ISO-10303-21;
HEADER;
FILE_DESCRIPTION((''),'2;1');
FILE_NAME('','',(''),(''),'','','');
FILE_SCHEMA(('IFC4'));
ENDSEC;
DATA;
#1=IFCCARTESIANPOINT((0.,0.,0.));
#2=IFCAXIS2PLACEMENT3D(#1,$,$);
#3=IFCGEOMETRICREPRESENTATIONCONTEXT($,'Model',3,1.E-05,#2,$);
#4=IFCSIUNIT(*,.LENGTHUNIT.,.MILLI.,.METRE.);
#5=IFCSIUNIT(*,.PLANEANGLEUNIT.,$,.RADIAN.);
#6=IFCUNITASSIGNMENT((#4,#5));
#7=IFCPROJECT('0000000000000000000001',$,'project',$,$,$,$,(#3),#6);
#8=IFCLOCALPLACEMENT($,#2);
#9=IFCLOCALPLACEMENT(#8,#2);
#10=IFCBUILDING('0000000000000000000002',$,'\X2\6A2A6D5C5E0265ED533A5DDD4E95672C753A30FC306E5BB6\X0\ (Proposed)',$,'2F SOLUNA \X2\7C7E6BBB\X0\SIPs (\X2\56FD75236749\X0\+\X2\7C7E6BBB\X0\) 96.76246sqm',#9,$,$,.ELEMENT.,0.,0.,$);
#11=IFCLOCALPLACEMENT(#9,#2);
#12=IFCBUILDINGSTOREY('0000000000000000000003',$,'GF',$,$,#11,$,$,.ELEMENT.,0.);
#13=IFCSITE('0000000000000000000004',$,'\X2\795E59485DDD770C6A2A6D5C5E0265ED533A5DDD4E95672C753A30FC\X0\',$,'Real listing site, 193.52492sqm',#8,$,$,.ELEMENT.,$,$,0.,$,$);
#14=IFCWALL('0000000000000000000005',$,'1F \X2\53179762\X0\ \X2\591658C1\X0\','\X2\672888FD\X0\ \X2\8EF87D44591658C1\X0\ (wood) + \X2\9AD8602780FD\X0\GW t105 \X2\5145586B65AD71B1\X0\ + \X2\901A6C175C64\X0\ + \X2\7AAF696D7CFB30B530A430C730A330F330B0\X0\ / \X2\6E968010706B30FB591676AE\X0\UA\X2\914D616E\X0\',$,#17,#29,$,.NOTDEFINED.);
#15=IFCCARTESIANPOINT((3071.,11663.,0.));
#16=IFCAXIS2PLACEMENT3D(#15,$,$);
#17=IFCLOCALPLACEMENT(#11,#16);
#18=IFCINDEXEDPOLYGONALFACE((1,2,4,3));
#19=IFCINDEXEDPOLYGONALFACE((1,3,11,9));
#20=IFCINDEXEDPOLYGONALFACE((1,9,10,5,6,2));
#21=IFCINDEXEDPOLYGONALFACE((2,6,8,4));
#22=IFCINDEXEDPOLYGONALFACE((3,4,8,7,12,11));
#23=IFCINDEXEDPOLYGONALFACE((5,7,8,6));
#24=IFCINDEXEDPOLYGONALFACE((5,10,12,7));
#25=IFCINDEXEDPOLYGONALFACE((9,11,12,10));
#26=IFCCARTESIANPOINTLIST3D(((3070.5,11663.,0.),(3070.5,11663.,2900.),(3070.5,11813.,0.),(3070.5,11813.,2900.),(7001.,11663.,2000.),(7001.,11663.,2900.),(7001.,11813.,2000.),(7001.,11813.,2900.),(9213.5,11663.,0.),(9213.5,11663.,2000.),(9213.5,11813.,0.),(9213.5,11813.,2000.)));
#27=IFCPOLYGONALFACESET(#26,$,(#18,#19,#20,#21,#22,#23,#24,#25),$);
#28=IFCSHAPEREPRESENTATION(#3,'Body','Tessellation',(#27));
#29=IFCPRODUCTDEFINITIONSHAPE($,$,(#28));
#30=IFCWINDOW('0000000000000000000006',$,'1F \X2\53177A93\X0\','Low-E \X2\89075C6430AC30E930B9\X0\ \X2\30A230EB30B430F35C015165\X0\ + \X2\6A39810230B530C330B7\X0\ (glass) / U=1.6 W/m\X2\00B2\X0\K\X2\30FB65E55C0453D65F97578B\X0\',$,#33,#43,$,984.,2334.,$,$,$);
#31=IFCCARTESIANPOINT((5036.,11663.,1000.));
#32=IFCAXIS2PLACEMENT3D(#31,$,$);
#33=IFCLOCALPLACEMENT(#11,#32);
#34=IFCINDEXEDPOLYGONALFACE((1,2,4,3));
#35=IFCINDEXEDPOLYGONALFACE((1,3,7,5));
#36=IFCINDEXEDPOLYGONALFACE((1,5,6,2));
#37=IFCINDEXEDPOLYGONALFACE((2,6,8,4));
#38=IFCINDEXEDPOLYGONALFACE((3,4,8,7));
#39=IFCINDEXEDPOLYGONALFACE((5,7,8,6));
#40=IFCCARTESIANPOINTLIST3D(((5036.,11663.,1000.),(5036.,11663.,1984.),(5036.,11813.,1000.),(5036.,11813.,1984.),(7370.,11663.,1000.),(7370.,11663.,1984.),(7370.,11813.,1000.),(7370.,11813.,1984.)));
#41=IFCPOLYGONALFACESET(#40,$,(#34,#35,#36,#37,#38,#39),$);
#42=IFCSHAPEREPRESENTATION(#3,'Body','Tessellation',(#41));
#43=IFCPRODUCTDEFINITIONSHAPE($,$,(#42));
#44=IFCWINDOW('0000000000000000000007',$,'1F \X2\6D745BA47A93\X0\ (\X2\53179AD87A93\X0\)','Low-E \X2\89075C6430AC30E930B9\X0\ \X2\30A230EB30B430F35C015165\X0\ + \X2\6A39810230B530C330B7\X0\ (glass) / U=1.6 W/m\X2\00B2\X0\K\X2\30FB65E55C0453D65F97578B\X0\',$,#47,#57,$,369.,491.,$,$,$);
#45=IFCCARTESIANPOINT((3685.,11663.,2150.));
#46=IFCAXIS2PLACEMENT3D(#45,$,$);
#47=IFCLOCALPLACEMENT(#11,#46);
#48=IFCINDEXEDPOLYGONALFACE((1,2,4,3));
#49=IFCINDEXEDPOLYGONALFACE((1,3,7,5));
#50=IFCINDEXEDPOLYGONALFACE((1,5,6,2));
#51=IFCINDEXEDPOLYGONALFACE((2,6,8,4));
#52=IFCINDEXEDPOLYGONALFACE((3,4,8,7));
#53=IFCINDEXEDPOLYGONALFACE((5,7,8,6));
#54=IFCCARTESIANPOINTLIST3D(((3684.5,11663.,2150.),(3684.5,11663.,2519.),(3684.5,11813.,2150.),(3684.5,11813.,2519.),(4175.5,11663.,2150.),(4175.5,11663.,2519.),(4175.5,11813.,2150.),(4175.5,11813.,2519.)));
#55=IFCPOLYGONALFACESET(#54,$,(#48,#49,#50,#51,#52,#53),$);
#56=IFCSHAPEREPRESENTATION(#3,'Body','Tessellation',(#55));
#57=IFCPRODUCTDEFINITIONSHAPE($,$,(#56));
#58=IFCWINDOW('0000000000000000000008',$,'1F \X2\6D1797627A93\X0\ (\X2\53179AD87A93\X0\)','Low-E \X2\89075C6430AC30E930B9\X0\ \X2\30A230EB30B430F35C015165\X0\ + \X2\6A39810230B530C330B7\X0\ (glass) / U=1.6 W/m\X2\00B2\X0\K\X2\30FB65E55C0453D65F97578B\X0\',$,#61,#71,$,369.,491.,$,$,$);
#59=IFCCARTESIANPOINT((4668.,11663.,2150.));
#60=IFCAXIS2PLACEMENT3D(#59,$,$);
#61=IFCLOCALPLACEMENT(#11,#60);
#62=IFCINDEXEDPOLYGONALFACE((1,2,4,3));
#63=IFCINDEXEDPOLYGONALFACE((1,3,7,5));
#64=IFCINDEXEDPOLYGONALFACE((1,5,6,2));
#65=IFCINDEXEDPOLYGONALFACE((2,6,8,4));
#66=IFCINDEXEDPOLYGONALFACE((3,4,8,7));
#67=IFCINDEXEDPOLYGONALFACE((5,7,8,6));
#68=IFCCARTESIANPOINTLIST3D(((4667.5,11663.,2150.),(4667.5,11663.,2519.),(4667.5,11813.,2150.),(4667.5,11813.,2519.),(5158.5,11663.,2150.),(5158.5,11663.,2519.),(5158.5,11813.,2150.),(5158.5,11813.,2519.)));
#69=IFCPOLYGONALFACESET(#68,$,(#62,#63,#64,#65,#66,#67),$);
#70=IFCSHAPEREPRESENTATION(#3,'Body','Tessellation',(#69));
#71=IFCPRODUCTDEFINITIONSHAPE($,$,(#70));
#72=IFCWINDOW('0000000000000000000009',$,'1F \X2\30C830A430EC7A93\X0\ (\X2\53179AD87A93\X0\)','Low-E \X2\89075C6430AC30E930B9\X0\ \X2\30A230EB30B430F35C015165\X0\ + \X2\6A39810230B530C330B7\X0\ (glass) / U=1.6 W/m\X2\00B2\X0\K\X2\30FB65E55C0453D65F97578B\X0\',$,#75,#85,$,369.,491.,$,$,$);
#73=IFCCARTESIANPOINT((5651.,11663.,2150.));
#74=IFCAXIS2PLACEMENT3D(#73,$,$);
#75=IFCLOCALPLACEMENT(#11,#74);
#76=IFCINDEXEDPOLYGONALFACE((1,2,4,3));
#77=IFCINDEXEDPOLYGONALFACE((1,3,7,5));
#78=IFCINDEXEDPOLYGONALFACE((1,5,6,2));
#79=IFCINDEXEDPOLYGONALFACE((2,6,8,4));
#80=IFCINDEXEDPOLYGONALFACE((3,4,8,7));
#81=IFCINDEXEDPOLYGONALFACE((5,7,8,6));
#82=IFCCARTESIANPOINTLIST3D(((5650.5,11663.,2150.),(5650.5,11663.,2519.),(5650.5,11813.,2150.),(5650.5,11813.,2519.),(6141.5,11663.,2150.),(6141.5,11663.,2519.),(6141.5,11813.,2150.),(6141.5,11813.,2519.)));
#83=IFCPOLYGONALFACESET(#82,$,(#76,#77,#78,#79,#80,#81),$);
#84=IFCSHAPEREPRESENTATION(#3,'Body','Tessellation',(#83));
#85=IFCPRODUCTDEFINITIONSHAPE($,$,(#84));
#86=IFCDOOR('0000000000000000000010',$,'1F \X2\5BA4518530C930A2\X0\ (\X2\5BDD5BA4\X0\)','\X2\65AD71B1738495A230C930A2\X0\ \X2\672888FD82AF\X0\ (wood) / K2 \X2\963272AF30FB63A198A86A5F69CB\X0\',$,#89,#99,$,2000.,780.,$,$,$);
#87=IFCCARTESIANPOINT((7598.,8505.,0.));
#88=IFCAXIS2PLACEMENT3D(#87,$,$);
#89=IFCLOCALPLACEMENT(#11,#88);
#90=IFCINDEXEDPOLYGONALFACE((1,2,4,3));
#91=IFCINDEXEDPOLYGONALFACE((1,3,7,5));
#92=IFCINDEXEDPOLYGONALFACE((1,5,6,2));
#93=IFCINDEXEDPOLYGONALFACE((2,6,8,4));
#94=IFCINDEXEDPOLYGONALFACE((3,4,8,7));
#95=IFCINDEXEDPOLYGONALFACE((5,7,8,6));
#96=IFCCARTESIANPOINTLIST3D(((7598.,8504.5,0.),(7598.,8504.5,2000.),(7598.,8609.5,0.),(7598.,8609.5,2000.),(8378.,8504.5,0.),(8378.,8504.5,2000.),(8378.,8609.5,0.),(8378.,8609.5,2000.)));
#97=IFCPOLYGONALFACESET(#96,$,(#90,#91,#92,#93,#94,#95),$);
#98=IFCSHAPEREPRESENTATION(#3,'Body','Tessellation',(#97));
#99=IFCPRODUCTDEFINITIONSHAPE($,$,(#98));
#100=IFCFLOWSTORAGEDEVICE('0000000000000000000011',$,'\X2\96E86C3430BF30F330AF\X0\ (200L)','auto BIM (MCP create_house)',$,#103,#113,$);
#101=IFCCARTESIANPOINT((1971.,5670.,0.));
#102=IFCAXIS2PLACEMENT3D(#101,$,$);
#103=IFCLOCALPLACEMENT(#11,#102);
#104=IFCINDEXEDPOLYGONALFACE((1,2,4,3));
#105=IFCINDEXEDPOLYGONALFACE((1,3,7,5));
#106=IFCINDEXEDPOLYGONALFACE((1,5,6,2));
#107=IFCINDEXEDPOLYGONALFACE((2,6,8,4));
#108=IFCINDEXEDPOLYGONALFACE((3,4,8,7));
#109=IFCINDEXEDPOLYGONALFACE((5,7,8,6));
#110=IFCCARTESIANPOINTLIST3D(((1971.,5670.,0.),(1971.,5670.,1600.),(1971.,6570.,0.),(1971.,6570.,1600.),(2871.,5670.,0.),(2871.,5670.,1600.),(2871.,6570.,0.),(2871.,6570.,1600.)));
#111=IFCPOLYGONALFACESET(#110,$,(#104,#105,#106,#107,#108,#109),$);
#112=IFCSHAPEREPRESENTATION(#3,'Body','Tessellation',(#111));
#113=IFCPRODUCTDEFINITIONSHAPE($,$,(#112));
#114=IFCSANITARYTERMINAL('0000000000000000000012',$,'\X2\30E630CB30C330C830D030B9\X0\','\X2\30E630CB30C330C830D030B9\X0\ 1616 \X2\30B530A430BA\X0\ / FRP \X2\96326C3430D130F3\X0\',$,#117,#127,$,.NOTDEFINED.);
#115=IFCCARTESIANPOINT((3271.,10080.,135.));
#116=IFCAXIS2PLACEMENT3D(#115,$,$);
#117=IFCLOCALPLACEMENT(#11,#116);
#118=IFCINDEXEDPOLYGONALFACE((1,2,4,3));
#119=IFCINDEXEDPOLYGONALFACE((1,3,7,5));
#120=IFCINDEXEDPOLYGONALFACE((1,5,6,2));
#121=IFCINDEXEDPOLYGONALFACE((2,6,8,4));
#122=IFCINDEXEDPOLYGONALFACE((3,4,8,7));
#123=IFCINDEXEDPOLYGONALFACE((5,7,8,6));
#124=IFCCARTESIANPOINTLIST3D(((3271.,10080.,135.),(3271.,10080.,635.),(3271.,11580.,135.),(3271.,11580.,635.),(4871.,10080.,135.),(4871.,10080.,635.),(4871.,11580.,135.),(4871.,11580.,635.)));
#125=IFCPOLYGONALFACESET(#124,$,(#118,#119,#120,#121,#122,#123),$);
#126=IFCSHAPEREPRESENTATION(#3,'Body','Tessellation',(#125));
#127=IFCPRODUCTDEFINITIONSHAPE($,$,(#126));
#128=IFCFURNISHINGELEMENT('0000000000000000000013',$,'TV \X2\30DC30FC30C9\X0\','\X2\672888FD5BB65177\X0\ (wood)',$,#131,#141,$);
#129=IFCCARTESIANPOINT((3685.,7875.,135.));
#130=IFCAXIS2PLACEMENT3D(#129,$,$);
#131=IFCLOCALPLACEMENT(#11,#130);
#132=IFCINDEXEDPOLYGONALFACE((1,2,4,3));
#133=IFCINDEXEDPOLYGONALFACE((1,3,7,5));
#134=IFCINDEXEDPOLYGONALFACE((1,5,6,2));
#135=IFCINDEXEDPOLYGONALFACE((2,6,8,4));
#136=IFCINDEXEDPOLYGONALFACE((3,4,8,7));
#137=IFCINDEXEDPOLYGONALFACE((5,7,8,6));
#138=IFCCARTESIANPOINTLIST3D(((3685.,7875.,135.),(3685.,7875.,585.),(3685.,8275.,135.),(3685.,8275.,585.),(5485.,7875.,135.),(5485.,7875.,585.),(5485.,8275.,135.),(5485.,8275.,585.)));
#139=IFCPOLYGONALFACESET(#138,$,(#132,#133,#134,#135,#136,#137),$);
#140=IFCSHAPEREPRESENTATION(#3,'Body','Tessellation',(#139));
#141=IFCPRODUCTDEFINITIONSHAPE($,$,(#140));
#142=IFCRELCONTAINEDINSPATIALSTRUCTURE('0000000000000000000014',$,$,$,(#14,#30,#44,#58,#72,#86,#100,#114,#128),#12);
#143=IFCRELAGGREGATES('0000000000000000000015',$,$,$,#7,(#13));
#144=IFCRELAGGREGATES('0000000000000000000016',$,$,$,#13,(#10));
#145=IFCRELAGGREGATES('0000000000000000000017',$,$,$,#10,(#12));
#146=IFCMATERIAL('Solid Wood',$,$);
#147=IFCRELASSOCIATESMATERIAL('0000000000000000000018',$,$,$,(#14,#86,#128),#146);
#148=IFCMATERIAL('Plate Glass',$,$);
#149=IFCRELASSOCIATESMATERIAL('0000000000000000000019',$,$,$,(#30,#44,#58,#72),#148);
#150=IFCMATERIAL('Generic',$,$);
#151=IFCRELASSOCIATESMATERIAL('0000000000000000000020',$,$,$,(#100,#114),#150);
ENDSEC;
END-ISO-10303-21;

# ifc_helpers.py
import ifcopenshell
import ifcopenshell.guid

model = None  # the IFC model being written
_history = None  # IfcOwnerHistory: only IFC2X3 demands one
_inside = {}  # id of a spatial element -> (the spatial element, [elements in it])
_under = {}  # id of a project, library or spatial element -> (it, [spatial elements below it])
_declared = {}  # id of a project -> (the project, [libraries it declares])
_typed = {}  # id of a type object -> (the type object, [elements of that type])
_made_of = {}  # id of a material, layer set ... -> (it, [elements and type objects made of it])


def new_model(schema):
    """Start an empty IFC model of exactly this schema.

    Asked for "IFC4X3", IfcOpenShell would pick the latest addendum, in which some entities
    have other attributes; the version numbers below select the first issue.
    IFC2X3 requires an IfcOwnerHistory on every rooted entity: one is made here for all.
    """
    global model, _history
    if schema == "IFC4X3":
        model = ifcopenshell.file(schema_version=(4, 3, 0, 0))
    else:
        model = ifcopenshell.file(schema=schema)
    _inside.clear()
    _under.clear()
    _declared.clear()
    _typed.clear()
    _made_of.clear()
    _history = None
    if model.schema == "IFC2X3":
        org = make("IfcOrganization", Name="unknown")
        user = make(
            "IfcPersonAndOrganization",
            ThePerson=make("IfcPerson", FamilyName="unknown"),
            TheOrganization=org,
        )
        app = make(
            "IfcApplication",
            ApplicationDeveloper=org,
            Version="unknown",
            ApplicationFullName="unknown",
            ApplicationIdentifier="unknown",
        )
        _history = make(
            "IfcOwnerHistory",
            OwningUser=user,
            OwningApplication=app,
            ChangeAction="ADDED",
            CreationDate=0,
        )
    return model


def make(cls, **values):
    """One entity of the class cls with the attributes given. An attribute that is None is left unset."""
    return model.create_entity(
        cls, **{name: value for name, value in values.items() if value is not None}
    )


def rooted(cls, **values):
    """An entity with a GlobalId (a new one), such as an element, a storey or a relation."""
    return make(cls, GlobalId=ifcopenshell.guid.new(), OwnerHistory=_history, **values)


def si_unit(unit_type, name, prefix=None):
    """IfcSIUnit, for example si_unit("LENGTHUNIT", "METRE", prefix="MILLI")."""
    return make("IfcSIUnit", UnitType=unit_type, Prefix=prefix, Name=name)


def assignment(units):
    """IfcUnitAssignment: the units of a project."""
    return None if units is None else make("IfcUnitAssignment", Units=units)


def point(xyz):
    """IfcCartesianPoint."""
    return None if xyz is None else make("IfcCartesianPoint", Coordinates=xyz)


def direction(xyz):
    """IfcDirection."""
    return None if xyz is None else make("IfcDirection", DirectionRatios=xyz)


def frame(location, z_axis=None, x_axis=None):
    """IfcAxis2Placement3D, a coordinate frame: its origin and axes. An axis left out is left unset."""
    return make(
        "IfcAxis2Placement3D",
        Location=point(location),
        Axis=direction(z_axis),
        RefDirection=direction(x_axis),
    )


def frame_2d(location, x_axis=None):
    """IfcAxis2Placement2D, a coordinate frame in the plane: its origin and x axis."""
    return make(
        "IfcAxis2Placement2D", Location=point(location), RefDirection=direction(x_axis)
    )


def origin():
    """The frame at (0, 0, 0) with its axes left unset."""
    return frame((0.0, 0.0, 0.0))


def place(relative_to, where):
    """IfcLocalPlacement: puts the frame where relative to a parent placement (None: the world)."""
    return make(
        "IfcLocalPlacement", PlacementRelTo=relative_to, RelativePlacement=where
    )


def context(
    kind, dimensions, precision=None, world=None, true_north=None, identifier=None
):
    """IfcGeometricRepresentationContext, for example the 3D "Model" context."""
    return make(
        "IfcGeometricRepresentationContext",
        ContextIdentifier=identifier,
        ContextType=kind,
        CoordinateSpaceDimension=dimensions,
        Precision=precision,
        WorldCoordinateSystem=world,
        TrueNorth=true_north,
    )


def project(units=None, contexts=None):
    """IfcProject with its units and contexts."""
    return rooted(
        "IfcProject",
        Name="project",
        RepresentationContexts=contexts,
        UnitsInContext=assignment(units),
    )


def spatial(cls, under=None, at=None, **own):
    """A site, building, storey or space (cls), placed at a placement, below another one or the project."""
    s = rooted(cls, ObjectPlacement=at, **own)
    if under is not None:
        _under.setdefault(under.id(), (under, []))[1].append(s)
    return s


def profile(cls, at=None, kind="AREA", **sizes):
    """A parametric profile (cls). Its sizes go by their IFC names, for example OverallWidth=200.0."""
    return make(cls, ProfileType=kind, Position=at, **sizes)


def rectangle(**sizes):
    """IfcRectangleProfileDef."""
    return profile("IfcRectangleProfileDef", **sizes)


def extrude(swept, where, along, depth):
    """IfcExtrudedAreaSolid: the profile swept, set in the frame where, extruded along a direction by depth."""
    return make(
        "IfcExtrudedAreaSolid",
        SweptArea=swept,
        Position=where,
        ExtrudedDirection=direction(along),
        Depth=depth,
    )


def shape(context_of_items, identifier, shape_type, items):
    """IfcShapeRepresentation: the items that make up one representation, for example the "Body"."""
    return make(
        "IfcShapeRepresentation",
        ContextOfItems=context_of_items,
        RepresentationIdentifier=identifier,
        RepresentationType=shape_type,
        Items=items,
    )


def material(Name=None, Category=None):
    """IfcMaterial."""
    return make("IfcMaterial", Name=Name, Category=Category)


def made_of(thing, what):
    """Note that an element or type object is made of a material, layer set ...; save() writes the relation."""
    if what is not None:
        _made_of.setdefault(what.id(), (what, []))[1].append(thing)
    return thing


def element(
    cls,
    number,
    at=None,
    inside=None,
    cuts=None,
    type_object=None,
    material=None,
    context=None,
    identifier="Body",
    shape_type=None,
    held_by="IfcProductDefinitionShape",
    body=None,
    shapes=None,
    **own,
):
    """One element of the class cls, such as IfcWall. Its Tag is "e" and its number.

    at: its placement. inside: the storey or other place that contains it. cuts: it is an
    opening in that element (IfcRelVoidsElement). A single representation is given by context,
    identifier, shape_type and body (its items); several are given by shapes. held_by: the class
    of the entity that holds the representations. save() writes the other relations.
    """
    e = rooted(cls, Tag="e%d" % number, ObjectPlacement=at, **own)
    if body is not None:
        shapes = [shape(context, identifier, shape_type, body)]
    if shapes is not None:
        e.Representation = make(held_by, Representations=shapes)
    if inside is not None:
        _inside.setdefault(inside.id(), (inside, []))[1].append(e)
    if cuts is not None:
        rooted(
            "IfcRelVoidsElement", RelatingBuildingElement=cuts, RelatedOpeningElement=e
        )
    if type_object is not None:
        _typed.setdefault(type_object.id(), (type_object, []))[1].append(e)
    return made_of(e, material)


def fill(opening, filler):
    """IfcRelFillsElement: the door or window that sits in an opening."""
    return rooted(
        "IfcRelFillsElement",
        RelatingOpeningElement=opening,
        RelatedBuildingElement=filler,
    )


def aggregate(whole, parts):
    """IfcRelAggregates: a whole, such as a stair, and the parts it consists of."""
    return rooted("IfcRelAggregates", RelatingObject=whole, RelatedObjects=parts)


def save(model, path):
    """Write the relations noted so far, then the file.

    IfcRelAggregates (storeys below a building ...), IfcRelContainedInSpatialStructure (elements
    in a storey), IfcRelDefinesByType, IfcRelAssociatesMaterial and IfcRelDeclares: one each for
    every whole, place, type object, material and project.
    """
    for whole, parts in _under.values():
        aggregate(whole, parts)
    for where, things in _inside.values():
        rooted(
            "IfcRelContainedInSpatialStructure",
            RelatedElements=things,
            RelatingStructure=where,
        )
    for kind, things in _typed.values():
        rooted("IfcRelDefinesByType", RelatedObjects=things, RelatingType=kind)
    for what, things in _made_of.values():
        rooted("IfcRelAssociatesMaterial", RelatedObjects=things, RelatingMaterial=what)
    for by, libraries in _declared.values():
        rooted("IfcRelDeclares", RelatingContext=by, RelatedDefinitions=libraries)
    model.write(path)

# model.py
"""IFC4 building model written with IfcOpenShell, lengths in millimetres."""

from ifc_helpers import new_model, si_unit, frame, frame_2d, origin, place, context, project, spatial, rectangle, extrude, material, element, fill, save


model = new_model("IFC4")

# Units and contexts
model_context = context("Model", 3, precision=1e-05, world=origin())
ifc_project = project(units=[si_unit("LENGTHUNIT", "METRE", prefix="MILLI"), si_unit("PLANEANGLEUNIT", "RADIAN")], contexts=[model_context])

# Site, building, storey
site_placement = place(None, origin())
site = spatial("IfcSite", under=ifc_project, at=site_placement, Name="神奈川県横浜市旭区川井本町ー", ObjectType="Real listing site, 193.52492sqm", CompositionType="ELEMENT", RefElevation=0.0)
building_placement = place(site_placement, origin())
building = spatial("IfcBuilding", under=site, at=building_placement, Name="横浜市旭区川井本町ーの家 (Proposed)", ObjectType="2F SOLUNA 籾殻SIPs (国産杉+籾殻) 96.76246sqm", CompositionType="ELEMENT", ElevationOfRefHeight=0.0, ElevationOfTerrain=0.0)
storey_placement = place(building_placement, origin())
storey = spatial("IfcBuildingStorey", under=building, at=storey_placement, Name="GF", CompositionType="ELEMENT", Elevation=0.0)

# Wall, openings, windows
ifc_material_1 = material(Name="Solid Wood")
wall_1_placement = place(storey_placement, frame((3071.0, 11663.0, 0.0)))
wall_1 = element("IfcWall", 1, at=wall_1_placement, inside=storey, material=ifc_material_1, Name="1F 北面 外壁", Description="木製 軸組外壁 (wood) + 高性能GW t105 充填断熱 + 通気層 + 窯業系サイディング / 準耐火・外皮UA配慮", PredefinedType="NOTDEFINED", context=model_context, shape_type="SweptSolid", body=[
    extrude(rectangle(XDim=6143.0, YDim=150.0, at=frame_2d((3071.0, 75.0))), frame((3071.0, 11663.0, 0.0)), (0.0, 0.0, 1.0), 2900.0),
])
opening_1_placement = place(storey_placement, frame((5036.0, 11663.0, 1000.0)))
opening_1 = element("IfcOpeningElement", 2, at=opening_1_placement, cuts=wall_1, PredefinedType="NOTDEFINED", context=model_context, shape_type="SweptSolid", body=[
    extrude(rectangle(XDim=2334.0, YDim=150.0, at=frame_2d((1167.0, 75.0))), frame((5036.0, 11663.0, 1000.0)), (0.0, 0.0, 1.0), 984.0),
])
opening_2_placement = place(storey_placement, frame((3685.0, 11663.0, 2150.0)))
opening_2 = element("IfcOpeningElement", 3, at=opening_2_placement, cuts=wall_1, PredefinedType="NOTDEFINED", context=model_context, shape_type="SweptSolid", body=[
    extrude(rectangle(XDim=491.0, YDim=150.0, at=frame_2d((245.0, 75.0))), frame((3685.0, 11663.0, 2150.0)), (0.0, 0.0, 1.0), 369.0),
])
opening_3_placement = place(storey_placement, frame((4668.0, 11663.0, 2150.0)))
opening_3 = element("IfcOpeningElement", 4, at=opening_3_placement, cuts=wall_1, PredefinedType="NOTDEFINED", context=model_context, shape_type="SweptSolid", body=[
    extrude(rectangle(XDim=491.0, YDim=150.0, at=frame_2d((245.0, 75.0))), frame((4668.0, 11663.0, 2150.0)), (0.0, 0.0, 1.0), 369.0),
])
opening_4_placement = place(storey_placement, frame((5651.0, 11663.0, 2150.0)))
opening_4 = element("IfcOpeningElement", 5, at=opening_4_placement, cuts=wall_1, PredefinedType="NOTDEFINED", context=model_context, shape_type="SweptSolid", body=[
    extrude(rectangle(XDim=491.0, YDim=150.0, at=frame_2d((245.0, 75.0))), frame((5651.0, 11663.0, 2150.0)), (0.0, 0.0, 1.0), 369.0),
])
ifc_material_2 = material(Name="Plate Glass")
window_1_placement = place(storey_placement, frame((5036.0, 11663.0, 1000.0)))
window_1 = element("IfcWindow", 6, at=window_1_placement, inside=storey, material=ifc_material_2, Name="1F 北窓", Description="Low-E 複層ガラス アルゴン封入 + 樹脂サッシ (glass) / U=1.6 W/m²K・日射取得型", OverallHeight=984.0, OverallWidth=2334.0, context=model_context, shape_type="SweptSolid", body=[
    extrude(rectangle(XDim=2334.0, YDim=150.0, at=frame_2d((1167.0, 75.0))), frame((5036.0, 11663.0, 1000.0)), (0.0, 0.0, 1.0), 984.0),
])
fill(opening_1, window_1)
window_2_placement = place(storey_placement, frame((3685.0, 11663.0, 2150.0)))
window_2 = element("IfcWindow", 7, at=window_2_placement, inside=storey, material=ifc_material_2, Name="1F 浴室窓 (北高窓)", Description="Low-E 複層ガラス アルゴン封入 + 樹脂サッシ (glass) / U=1.6 W/m²K・日射取得型", OverallHeight=369.0, OverallWidth=491.0, context=model_context, shape_type="SweptSolid", body=[
    extrude(rectangle(XDim=491.0, YDim=150.0, at=frame_2d((245.0, 75.0))), frame((3685.0, 11663.0, 2150.0)), (0.0, 0.0, 1.0), 369.0),
])
fill(opening_2, window_2)
window_3_placement = place(storey_placement, frame((4668.0, 11663.0, 2150.0)))
window_3 = element("IfcWindow", 8, at=window_3_placement, inside=storey, material=ifc_material_2, Name="1F 洗面窓 (北高窓)", Description="Low-E 複層ガラス アルゴン封入 + 樹脂サッシ (glass) / U=1.6 W/m²K・日射取得型", OverallHeight=369.0, OverallWidth=491.0, context=model_context, shape_type="SweptSolid", body=[
    extrude(rectangle(XDim=491.0, YDim=150.0, at=frame_2d((245.0, 75.0))), frame((4668.0, 11663.0, 2150.0)), (0.0, 0.0, 1.0), 369.0),
])
fill(opening_3, window_3)
window_4_placement = place(storey_placement, frame((5651.0, 11663.0, 2150.0)))
window_4 = element("IfcWindow", 9, at=window_4_placement, inside=storey, material=ifc_material_2, Name="1F トイレ窓 (北高窓)", Description="Low-E 複層ガラス アルゴン封入 + 樹脂サッシ (glass) / U=1.6 W/m²K・日射取得型", OverallHeight=369.0, OverallWidth=491.0, context=model_context, shape_type="SweptSolid", body=[
    extrude(rectangle(XDim=491.0, YDim=150.0, at=frame_2d((245.0, 75.0))), frame((5651.0, 11663.0, 2150.0)), (0.0, 0.0, 1.0), 369.0),
])
fill(opening_4, window_4)

# Door
door_1_placement = place(storey_placement, frame((7598.0, 8505.0, 0.0)))
element("IfcDoor", 10, at=door_1_placement, inside=storey, material=ifc_material_1, Name="1F 室内ドア (寝室)", Description="断熱玄関ドア 木製芯 (wood) / K2 防犯・採風機構", OverallHeight=2000.0, OverallWidth=780.0, context=model_context, shape_type="SweptSolid", body=[
    extrude(rectangle(XDim=780.0, YDim=105.0, at=frame_2d((390.0, 52.0))), frame((7598.0, 8505.0, 0.0)), (0.0, 0.0, 1.0), 2000.0),
])

# Flow storage device
ifc_material_3 = material(Name="Generic")
flow_storage_device_placement = place(storey_placement, frame((1971.0, 5670.0, 0.0)))
element("IfcFlowStorageDevice", 11, at=flow_storage_device_placement, inside=storey, material=ifc_material_3, Name="雨水タンク (200L)", Description="auto BIM (MCP create_house)", context=model_context, shape_type="SweptSolid", body=[
    extrude(rectangle(XDim=900.0, YDim=900.0, at=frame_2d((450.0, 450.0))), frame((1971.0, 5670.0, 0.0)), (0.0, 0.0, 1.0), 1600.0),
])

# Sanitary terminal
sanitary_terminal_placement = place(storey_placement, frame((3271.0, 10080.0, 135.0)))
element("IfcSanitaryTerminal", 12, at=sanitary_terminal_placement, inside=storey, material=ifc_material_3, Name="ユニットバス", Description="ユニットバス 1616 サイズ / FRP 防水パン", PredefinedType="NOTDEFINED", context=model_context, shape_type="SweptSolid", body=[
    extrude(rectangle(XDim=1600.0, YDim=1500.0, at=frame_2d((800.0, 750.0))), frame((3271.0, 10080.0, 135.0)), (0.0, 0.0, 1.0), 500.0),
])

# Furnishing element
furnishing_placement = place(storey_placement, frame((3685.0, 7875.0, 135.0)))
element("IfcFurnishingElement", 13, at=furnishing_placement, inside=storey, material=ifc_material_1, Name="TV ボード", Description="木製家具 (wood)", context=model_context, shape_type="SweptSolid", body=[
    extrude(rectangle(XDim=1800.0, YDim=400.0, at=frame_2d((900.0, 200.0))), frame((3685.0, 7875.0, 135.0)), (0.0, 0.0, 1.0), 450.0),
])

save(model, "model.ifc")
